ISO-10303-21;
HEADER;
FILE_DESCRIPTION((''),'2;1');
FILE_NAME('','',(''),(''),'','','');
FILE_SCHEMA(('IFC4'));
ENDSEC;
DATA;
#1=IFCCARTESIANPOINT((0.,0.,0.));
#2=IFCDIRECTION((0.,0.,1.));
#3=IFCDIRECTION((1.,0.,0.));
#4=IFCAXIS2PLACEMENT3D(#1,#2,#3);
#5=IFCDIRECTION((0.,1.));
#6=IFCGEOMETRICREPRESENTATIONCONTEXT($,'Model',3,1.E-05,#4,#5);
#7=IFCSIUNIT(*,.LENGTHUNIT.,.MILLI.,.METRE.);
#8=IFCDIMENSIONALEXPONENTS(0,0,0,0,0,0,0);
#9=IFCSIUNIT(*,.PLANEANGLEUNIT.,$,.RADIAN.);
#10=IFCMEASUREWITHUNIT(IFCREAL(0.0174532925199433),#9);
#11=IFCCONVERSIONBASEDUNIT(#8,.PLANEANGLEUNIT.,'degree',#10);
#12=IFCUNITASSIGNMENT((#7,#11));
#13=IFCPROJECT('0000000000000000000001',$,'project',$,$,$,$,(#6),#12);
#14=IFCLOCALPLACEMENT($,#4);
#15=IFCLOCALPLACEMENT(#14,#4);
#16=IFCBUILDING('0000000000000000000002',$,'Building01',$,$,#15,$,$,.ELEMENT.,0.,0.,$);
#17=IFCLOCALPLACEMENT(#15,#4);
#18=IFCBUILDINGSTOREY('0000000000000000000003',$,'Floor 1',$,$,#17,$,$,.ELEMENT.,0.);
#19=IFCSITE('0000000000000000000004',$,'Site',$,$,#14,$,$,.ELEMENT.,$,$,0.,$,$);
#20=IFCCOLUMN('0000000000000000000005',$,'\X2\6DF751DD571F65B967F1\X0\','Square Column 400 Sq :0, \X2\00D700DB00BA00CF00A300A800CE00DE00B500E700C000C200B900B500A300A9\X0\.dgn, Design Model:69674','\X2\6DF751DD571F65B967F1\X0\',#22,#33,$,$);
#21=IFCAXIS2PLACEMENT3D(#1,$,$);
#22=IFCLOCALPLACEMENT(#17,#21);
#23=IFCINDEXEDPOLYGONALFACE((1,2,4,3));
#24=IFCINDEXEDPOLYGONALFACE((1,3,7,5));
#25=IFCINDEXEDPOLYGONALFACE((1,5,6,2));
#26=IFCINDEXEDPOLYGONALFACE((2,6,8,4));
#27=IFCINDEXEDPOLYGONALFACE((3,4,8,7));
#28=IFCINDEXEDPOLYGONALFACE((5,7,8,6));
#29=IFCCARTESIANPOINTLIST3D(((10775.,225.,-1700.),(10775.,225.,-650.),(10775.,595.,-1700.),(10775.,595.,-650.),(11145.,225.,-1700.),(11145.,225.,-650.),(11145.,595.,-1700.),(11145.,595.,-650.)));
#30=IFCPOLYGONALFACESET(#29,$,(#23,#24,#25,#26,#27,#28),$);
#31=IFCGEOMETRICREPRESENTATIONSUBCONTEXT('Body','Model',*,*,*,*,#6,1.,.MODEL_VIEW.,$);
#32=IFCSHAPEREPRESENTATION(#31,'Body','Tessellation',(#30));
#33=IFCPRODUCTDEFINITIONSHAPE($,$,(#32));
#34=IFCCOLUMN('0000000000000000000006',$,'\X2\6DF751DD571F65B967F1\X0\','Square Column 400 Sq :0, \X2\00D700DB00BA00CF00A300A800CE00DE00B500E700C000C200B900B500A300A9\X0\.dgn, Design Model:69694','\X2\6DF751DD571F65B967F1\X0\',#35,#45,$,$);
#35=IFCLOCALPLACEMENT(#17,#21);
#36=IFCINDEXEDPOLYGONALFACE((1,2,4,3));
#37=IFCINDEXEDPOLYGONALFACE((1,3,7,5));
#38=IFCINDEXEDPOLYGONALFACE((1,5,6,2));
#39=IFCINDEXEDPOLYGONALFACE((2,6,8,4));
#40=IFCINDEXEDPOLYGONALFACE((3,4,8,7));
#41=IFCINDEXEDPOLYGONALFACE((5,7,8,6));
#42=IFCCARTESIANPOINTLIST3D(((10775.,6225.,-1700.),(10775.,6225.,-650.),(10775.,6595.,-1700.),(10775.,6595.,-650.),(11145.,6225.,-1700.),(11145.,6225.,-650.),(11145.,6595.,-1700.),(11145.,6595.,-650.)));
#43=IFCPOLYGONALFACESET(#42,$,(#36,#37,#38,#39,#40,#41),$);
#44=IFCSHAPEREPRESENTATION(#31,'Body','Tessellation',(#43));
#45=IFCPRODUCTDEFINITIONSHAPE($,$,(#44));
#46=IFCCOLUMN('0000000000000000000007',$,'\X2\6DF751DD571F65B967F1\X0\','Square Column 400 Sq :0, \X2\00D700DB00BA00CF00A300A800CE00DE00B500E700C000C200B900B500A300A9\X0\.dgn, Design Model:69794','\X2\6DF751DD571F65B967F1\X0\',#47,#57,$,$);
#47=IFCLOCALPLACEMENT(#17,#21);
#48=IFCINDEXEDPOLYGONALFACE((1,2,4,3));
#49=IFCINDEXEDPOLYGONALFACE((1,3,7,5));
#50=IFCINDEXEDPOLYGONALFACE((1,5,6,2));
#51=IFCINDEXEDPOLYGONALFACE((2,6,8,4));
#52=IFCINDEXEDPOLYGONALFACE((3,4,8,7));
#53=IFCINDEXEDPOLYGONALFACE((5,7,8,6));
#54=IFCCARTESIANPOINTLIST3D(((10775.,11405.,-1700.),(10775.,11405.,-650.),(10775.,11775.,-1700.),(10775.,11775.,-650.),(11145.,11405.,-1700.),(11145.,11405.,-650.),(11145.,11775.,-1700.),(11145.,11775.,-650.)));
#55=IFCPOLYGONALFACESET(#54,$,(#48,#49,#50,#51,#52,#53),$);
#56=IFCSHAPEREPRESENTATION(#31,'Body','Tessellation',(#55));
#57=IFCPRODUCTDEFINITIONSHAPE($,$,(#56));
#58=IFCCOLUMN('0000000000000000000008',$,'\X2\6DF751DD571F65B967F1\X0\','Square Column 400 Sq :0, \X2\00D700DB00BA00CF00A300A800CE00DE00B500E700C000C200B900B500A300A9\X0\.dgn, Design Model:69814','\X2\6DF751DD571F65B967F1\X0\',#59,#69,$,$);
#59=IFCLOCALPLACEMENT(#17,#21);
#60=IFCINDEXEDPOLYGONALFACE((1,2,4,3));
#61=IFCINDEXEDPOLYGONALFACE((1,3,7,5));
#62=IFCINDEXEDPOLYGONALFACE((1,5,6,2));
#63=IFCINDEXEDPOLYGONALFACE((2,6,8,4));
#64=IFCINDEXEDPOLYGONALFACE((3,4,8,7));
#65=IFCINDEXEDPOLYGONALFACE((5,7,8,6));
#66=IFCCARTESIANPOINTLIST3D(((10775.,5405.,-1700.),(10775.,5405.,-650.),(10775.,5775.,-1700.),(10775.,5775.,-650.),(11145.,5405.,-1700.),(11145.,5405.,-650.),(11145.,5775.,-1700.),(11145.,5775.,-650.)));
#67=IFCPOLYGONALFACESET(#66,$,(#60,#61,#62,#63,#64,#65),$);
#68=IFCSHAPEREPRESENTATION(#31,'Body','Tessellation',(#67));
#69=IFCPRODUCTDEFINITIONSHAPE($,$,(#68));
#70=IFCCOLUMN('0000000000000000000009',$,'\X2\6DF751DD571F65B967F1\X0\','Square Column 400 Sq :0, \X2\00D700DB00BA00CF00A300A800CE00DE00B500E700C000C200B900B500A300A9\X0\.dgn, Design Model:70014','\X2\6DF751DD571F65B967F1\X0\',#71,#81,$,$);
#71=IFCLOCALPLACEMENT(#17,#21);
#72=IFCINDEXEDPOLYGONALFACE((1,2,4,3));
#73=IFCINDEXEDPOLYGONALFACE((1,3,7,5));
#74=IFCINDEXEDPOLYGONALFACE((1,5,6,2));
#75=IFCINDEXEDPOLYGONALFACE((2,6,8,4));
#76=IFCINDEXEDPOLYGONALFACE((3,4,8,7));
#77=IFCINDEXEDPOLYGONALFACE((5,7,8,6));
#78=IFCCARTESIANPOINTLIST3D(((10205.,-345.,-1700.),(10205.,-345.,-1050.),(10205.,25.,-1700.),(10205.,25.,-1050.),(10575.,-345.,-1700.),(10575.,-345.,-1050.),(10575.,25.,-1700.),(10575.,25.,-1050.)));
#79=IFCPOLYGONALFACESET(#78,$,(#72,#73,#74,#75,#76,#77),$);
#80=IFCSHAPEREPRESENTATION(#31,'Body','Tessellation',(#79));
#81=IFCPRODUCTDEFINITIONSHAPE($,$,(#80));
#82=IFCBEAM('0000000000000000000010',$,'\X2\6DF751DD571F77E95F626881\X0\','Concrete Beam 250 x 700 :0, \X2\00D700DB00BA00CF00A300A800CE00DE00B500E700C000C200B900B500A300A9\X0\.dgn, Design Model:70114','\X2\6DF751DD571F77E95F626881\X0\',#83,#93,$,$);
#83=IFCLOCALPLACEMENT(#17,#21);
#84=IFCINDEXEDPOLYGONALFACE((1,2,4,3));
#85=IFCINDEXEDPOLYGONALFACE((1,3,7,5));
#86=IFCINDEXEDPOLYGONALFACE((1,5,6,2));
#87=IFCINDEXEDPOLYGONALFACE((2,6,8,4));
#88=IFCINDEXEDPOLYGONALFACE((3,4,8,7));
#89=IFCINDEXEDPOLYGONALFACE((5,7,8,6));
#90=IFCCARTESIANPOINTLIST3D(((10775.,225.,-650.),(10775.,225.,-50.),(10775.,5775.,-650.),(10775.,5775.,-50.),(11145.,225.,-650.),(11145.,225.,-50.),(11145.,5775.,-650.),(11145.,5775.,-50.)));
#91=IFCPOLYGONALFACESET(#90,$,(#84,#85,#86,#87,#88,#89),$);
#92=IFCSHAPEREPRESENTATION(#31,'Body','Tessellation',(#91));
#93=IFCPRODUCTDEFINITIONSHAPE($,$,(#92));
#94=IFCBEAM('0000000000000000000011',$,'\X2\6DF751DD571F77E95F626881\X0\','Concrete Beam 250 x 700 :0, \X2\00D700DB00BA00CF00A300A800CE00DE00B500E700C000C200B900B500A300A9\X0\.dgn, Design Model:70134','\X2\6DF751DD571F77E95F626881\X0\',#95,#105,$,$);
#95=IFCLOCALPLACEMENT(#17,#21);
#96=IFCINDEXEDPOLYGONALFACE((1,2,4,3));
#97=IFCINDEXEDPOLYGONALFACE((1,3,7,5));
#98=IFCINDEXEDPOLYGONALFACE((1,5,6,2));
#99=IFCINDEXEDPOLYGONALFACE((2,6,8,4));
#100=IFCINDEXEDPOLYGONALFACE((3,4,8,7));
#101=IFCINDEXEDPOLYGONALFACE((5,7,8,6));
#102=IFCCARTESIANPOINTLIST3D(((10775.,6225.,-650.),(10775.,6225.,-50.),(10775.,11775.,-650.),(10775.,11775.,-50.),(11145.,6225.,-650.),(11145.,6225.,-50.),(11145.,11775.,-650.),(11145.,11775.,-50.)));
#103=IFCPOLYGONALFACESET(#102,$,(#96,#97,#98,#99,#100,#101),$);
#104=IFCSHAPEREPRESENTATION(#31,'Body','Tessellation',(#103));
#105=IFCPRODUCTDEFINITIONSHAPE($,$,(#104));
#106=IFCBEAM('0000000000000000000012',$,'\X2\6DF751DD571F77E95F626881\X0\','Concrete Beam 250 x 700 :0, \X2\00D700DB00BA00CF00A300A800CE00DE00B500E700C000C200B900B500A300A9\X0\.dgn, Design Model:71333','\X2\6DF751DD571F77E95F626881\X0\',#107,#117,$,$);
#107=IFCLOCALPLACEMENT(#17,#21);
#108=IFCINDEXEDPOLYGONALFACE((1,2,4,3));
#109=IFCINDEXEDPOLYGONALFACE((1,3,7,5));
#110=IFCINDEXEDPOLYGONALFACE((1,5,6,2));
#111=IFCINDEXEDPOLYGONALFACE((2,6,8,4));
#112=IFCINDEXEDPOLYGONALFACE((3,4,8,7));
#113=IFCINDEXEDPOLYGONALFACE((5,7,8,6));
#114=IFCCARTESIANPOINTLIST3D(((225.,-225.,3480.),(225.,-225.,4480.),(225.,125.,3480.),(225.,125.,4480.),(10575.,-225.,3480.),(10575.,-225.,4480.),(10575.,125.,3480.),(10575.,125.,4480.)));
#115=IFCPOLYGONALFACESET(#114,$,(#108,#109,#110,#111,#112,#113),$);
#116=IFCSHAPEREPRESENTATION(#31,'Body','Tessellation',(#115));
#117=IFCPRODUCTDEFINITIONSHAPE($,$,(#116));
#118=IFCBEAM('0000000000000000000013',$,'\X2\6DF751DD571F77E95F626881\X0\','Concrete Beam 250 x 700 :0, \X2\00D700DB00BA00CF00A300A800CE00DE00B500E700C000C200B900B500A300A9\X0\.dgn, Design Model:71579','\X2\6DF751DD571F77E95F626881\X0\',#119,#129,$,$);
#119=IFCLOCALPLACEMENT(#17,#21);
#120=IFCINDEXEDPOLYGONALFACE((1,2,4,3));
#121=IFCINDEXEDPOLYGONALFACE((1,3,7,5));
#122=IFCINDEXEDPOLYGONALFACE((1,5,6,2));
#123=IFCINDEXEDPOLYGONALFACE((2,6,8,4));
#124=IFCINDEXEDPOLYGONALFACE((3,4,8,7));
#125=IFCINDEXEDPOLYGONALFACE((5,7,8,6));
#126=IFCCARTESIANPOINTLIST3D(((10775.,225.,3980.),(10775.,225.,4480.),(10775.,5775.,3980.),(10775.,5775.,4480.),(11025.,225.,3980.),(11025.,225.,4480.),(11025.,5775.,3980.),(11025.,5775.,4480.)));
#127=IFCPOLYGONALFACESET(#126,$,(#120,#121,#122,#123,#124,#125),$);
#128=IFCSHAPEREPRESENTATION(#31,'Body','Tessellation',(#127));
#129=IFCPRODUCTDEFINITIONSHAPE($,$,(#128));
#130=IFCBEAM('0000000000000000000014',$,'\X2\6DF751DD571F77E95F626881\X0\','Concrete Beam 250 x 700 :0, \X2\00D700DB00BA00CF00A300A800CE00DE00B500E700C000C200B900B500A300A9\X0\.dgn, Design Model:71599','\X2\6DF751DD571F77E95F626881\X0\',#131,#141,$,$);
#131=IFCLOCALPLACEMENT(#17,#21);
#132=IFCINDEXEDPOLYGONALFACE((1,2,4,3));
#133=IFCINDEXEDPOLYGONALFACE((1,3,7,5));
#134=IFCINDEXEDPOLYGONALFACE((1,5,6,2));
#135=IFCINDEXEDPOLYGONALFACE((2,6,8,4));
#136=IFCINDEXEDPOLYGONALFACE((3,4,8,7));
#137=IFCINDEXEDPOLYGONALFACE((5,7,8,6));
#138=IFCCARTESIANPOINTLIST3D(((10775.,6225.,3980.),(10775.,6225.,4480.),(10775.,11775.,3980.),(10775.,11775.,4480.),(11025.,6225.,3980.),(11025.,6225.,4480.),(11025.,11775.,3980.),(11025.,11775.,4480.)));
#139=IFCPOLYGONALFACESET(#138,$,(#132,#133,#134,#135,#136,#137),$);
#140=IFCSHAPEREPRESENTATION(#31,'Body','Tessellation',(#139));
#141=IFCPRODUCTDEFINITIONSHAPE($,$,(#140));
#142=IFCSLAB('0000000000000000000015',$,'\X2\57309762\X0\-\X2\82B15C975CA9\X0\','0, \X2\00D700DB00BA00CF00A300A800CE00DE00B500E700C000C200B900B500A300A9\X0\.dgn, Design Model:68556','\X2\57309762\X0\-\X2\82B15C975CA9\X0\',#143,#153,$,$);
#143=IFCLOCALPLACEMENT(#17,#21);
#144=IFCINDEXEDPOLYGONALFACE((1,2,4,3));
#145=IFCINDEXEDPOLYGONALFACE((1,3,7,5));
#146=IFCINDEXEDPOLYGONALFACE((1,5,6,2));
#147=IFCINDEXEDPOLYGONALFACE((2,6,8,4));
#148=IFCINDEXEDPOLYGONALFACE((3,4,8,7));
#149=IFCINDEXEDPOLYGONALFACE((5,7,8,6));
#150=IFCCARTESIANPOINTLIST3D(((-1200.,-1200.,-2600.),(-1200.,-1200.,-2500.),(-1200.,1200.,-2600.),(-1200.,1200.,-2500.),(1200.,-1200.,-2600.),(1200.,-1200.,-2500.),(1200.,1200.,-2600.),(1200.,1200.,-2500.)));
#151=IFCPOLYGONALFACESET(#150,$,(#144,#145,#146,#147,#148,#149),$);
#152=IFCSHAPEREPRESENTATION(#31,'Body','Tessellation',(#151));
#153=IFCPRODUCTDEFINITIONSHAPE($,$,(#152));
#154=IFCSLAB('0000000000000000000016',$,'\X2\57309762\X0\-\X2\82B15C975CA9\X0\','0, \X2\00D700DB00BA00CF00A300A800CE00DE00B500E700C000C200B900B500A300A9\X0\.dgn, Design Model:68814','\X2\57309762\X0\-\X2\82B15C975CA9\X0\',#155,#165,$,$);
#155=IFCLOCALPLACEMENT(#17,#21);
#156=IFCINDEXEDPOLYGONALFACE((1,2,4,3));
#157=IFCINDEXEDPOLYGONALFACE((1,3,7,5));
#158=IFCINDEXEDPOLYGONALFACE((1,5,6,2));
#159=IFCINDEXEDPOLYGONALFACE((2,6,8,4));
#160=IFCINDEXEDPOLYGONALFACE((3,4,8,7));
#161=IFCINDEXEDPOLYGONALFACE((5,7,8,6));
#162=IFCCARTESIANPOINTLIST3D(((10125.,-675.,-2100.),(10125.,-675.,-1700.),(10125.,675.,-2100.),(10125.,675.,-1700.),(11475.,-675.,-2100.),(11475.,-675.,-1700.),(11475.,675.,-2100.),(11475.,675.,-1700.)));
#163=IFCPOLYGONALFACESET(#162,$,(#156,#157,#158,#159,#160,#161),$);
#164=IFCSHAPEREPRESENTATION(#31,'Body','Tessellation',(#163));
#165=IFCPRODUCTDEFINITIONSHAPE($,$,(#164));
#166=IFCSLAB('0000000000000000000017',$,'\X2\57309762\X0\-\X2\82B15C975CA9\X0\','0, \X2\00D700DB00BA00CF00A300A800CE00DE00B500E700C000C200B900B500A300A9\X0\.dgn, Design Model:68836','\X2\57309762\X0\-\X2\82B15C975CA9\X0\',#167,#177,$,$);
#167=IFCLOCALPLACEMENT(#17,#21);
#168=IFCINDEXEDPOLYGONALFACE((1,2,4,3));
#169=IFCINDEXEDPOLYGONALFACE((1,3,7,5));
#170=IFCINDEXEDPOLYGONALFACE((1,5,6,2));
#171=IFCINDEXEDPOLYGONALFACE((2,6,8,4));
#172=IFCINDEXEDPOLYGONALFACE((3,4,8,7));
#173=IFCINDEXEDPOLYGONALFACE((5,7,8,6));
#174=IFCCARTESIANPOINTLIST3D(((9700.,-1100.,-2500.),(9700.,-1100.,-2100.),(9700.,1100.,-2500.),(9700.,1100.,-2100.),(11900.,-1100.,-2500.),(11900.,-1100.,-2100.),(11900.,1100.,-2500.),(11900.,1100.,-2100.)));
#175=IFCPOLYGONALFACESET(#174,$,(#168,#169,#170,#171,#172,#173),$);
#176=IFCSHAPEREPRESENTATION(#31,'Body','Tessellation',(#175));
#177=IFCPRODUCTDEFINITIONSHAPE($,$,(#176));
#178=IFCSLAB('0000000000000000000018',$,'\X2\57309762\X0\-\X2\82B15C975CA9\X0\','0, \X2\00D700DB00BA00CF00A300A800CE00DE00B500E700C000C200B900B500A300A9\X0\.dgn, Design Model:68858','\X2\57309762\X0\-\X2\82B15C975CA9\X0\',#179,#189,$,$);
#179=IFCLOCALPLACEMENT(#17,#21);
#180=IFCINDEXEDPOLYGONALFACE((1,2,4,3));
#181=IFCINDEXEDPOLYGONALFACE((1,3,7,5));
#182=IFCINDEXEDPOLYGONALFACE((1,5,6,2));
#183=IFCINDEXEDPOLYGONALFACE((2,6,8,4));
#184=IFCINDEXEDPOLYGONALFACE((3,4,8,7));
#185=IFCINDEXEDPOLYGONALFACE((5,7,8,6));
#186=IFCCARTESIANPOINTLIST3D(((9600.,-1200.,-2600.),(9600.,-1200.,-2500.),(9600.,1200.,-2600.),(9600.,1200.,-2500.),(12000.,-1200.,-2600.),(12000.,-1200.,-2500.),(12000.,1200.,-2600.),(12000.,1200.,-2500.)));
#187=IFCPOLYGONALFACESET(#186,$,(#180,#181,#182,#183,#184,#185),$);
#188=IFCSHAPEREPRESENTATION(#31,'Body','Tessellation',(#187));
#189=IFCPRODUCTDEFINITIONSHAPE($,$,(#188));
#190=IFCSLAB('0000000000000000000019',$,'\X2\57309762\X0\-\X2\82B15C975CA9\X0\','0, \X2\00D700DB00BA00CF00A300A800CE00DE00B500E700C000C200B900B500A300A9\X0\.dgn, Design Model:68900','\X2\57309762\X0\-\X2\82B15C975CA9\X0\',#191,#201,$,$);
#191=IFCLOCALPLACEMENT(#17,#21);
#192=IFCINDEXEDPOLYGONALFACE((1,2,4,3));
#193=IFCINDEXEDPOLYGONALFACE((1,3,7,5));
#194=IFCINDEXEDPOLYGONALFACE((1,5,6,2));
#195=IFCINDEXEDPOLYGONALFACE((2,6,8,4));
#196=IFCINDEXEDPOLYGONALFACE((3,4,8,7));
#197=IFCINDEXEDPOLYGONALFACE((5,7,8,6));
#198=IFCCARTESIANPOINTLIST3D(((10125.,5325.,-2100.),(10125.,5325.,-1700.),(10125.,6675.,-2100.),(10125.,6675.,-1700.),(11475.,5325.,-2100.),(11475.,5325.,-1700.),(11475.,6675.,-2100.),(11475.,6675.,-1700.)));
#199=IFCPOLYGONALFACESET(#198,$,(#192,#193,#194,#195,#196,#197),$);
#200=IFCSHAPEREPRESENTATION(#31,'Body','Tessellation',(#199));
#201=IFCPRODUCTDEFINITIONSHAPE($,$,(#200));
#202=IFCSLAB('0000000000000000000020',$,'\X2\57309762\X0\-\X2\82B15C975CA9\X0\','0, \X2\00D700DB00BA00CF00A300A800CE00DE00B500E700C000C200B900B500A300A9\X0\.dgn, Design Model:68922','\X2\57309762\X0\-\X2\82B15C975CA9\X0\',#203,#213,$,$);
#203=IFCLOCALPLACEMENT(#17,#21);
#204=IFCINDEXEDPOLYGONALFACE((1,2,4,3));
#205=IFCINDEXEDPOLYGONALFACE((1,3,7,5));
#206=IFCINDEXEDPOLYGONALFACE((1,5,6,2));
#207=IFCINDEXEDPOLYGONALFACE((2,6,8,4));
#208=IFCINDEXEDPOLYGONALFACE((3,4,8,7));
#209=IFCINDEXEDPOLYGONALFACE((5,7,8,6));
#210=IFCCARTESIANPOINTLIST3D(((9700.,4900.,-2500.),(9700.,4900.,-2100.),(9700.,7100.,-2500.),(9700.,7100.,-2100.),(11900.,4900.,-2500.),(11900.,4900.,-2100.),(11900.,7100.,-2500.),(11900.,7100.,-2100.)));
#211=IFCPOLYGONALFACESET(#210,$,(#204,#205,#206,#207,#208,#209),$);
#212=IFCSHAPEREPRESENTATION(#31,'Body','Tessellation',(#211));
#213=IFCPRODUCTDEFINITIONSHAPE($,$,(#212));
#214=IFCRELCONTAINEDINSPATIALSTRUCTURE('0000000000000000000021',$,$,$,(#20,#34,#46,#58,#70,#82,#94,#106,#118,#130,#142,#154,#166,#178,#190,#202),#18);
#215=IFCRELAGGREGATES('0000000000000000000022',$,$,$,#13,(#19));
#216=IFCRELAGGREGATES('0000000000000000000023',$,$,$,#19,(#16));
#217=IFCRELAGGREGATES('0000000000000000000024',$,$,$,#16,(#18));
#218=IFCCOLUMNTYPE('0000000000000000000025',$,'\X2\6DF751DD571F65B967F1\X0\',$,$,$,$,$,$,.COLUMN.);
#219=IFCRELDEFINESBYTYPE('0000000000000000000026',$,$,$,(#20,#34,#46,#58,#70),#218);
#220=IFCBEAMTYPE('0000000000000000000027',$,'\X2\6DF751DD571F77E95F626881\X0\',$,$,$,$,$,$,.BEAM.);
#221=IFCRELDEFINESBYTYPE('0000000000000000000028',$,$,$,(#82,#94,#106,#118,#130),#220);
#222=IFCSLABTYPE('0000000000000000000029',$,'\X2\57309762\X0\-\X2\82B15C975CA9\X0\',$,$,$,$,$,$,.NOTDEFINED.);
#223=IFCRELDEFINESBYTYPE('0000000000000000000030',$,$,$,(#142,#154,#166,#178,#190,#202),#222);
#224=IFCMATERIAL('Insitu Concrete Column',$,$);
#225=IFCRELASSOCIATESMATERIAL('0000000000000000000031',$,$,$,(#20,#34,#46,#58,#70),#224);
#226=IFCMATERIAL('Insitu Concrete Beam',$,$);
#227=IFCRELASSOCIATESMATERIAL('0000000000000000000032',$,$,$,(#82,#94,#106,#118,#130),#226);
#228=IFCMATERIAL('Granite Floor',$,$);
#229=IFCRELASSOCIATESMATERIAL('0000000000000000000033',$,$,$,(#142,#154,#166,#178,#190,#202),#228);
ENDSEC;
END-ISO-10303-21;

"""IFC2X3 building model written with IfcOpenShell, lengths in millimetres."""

from ifc_helpers import new_model, entity, si_unit, converted_unit, direction, frame, frame_2d, origin_with_axes, place, context, subcontext, project, spatial, rectangle, extrude, material, type_object, element, save


model = new_model("IFC2X3")

# Units and contexts
model_context = context("Model", 3, precision=1e-05, world=origin_with_axes(), true_north=direction((0.0, 1.0)))
body_context = subcontext(model_context, "Body", "Model", "MODEL_VIEW", scale=1.0)
ifc_project = project(units=[si_unit("LENGTHUNIT", "METRE", prefix="MILLI"), converted_unit("PLANEANGLEUNIT", "degree", entity("IfcReal", 0.0174532925199433), si_unit("PLANEANGLEUNIT", "RADIAN"), dimensions=[0, 0, 0, 0, 0, 0, 0])], contexts=[model_context])

# Site, building, storey
site_placement = place(None, origin_with_axes())
site = spatial("IfcSite", under=ifc_project, at=site_placement, Name="Site", CompositionType="ELEMENT", RefElevation=0.0)
building_placement = place(site_placement, origin_with_axes())
building = spatial("IfcBuilding", under=site, at=building_placement, Name="Building01", CompositionType="ELEMENT", ElevationOfRefHeight=0.0, ElevationOfTerrain=0.0)
storey_placement = place(building_placement, origin_with_axes())
storey = spatial("IfcBuildingStorey", under=building, at=storey_placement, Name="Floor 1", CompositionType="ELEMENT", Elevation=0.0)

# Columns
ifc_material_1 = material(Name="Insitu Concrete Column")
column_type = type_object("IfcColumnType", Name="混凝土方柱", PredefinedType="COLUMN")
for number, where, z_axis, x_axis, name, description in (
    (1, (10775.0, 595.0, -1700.0), (0.0, 0.0, 1.0), (0.0, -1.0, 0.0), "混凝土方柱", "Square Column 400 Sq :0, ×ÛºÏ£¨ÎÞµçÀÂ¹µ£©.dgn, Design Model:69674"),
    (2, (10775.0, 6595.0, -1700.0), (0.0, 0.0, 1.0), (0.0, -1.0, 0.0), "混凝土方柱", "Square Column 400 Sq :0, ×ÛºÏ£¨ÎÞµçÀÂ¹µ£©.dgn, Design Model:69694"),
    (3, (10775.0, 11405.0, -1700.0), (0.0, 0.0, 1.0), (1.0, 0.0, 0.0), "混凝土方柱", "Square Column 400 Sq :0, ×ÛºÏ£¨ÎÞµçÀÂ¹µ£©.dgn, Design Model:69794"),
    (4, (10775.0, 5405.0, -1700.0), (0.0, 0.0, 1.0), (1.0, 0.0, 0.0), "混凝土方柱", "Square Column 400 Sq :0, ×ÛºÏ£¨ÎÞµçÀÂ¹µ£©.dgn, Design Model:69814"),
):
    element("IfcColumn", number, at=place(storey_placement, frame(where, z_axis=z_axis, x_axis=x_axis)), inside=storey, type_object=column_type, material=ifc_material_1, Name=name, Description=description, ObjectType="混凝土方柱", context=body_context, shape_type="SweptSolid", body=[
        extrude(rectangle(XDim=370.0, YDim=370.0, at=frame_2d((185.0, 185.0), x_axis=(0.0, 1.0))), origin_with_axes(), (0.0, 0.0, 1.0), 1050.0),
    ])
column_placement = place(storey_placement, frame((10575.0, 25.0, -1700.0), z_axis=(0.0, 0.0, 1.0), x_axis=(-1.0, 0.0, 0.0)))
element("IfcColumn", 5, at=column_placement, inside=storey, type_object=column_type, material=ifc_material_1, Name="混凝土方柱", Description="Square Column 400 Sq :0, ×ÛºÏ£¨ÎÞµçÀÂ¹µ£©.dgn, Design Model:70014", ObjectType="混凝土方柱", context=body_context, shape_type="SweptSolid", body=[
    extrude(rectangle(XDim=370.0, YDim=370.0, at=frame_2d((185.0, 185.0), x_axis=(0.0, 1.0))), origin_with_axes(), (0.0, 0.0, 1.0), 650.0),
])

# Beams
ifc_material_2 = material(Name="Insitu Concrete Beam")
beam_type = type_object("IfcBeamType", Name="混凝土矩形梁", PredefinedType="BEAM")
for number, where, z_axis, x_axis, name, description in (
    (6, (11145.0, 225.0, -650.0), (0.0, 1.0, 0.0), (-1.0, 0.0, 0.0), "混凝土矩形梁", "Concrete Beam 250 x 700 :0, ×ÛºÏ£¨ÎÞµçÀÂ¹µ£©.dgn, Design Model:70114"),
    (7, (11145.0, 6225.0, -650.0), (0.0, 1.0, 0.0), (-1.0, 0.0, 0.0), "混凝土矩形梁", "Concrete Beam 250 x 700 :0, ×ÛºÏ£¨ÎÞµçÀÂ¹µ£©.dgn, Design Model:70134"),
):
    element("IfcBeam", number, at=place(storey_placement, frame(where, z_axis=z_axis, x_axis=x_axis)), inside=storey, type_object=beam_type, material=ifc_material_2, Name=name, Description=description, ObjectType="混凝土矩形梁", context=body_context, shape_type="SweptSolid", body=[
        extrude(rectangle(XDim=600.0, YDim=370.0, at=frame_2d((185.0, 300.0), x_axis=(0.0, 1.0))), origin_with_axes(), (0.0, 0.0, 1.0), 5550.0),
    ])
beam_placement = place(storey_placement, frame((10575.0, 125.0, 3480.0), z_axis=(-1.0, 0.0, 0.0), x_axis=(0.0, -1.0, 0.0)))
element("IfcBeam", 8, at=beam_placement, inside=storey, type_object=beam_type, material=ifc_material_2, Name="混凝土矩形梁", Description="Concrete Beam 250 x 700 :0, ×ÛºÏ£¨ÎÞµçÀÂ¹µ£©.dgn, Design Model:71333", ObjectType="混凝土矩形梁", context=body_context, shape_type="SweptSolid", body=[
    extrude(rectangle(XDim=1000.0, YDim=350.0, at=frame_2d((175.0, 500.0), x_axis=(0.0, 1.0))), origin_with_axes(), (0.0, 0.0, 1.0), 10350.0),
])
for number, where, z_axis, x_axis, name, description in (
    (9, (10775.0, 5775.0, 3980.0), (0.0, -1.0, 0.0), (1.0, 0.0, 0.0), "混凝土矩形梁", "Concrete Beam 250 x 700 :0, ×ÛºÏ£¨ÎÞµçÀÂ¹µ£©.dgn, Design Model:71579"),
    (10, (10775.0, 11775.0, 3980.0), (0.0, -1.0, 0.0), (1.0, 0.0, 0.0), "混凝土矩形梁", "Concrete Beam 250 x 700 :0, ×ÛºÏ£¨ÎÞµçÀÂ¹µ£©.dgn, Design Model:71599"),
):
    element("IfcBeam", number, at=place(storey_placement, frame(where, z_axis=z_axis, x_axis=x_axis)), inside=storey, type_object=beam_type, material=ifc_material_2, Name=name, Description=description, ObjectType="混凝土矩形梁", context=body_context, shape_type="SweptSolid", body=[
        extrude(rectangle(XDim=500.0, YDim=250.0, at=frame_2d((125.0, 250.0), x_axis=(0.0, 1.0))), origin_with_axes(), (0.0, 0.0, 1.0), 5550.0),
    ])

# Slabs
ifc_material_3 = material(Name="Granite Floor")
slab_type = type_object("IfcSlabType", Name="地面-花岗岩", PredefinedType="NOTDEFINED")
for number, where, z_axis, x_axis, name in (
    (11, (1200.0, 1200.0, -2500.0), (0.0, 0.0, -1.0), (0.0, -1.0, 0.0), "地面-花岗岩"),
):
    element("IfcSlab", number, at=place(storey_placement, frame(where, z_axis=z_axis, x_axis=x_axis)), inside=storey, type_object=slab_type, material=ifc_material_3, Name=name, Description="0, ×ÛºÏ£¨ÎÞµçÀÂ¹µ£©.dgn, Design Model:68556", ObjectType="地面-花岗岩", context=body_context, shape_type="SweptSolid", body=[
        extrude(rectangle(XDim=2400.0, YDim=2400.0, at=frame_2d((1200.0, 1200.0), x_axis=(1.0, 0.0))), origin_with_axes(), (0.0, 0.0, 1.0), 100.0),
    ])
slab_1_placement = place(storey_placement, frame((10125.0, -675.0, -2100.0), z_axis=(0.0, 0.0, 1.0), x_axis=(1.0, 0.0, 0.0)))
element("IfcSlab", 12, at=slab_1_placement, inside=storey, type_object=slab_type, material=ifc_material_3, Name="地面-花岗岩", Description="0, ×ÛºÏ£¨ÎÞµçÀÂ¹µ£©.dgn, Design Model:68814", ObjectType="地面-花岗岩", context=body_context, shape_type="SweptSolid", body=[
    extrude(rectangle(XDim=1350.0, YDim=1350.0, at=frame_2d((675.0, 675.0), x_axis=(1.0, 0.0))), origin_with_axes(), (0.0, 0.0, 1.0), 400.0),
])
slab_2_placement = place(storey_placement, frame((9700.0, -1100.0, -2500.0), z_axis=(0.0, 0.0, 1.0), x_axis=(1.0, 0.0, 0.0)))
element("IfcSlab", 13, at=slab_2_placement, inside=storey, type_object=slab_type, material=ifc_material_3, Name="地面-花岗岩", Description="0, ×ÛºÏ£¨ÎÞµçÀÂ¹µ£©.dgn, Design Model:68836", ObjectType="地面-花岗岩", context=body_context, shape_type="SweptSolid", body=[
    extrude(rectangle(XDim=2200.0, YDim=2200.0, at=frame_2d((1100.0, 1100.0), x_axis=(1.0, 0.0))), origin_with_axes(), (0.0, 0.0, 1.0), 400.0),
])
slab_3_placement = place(storey_placement, frame((12000.0, 1200.0, -2500.0), z_axis=(0.0, 0.0, -1.0), x_axis=(0.0, -1.0, 0.0)))
element("IfcSlab", 14, at=slab_3_placement, inside=storey, type_object=slab_type, material=ifc_material_3, Name="地面-花岗岩", Description="0, ×ÛºÏ£¨ÎÞµçÀÂ¹µ£©.dgn, Design Model:68858", ObjectType="地面-花岗岩", context=body_context, shape_type="SweptSolid", body=[
    extrude(rectangle(XDim=2400.0, YDim=2400.0, at=frame_2d((1200.0, 1200.0), x_axis=(1.0, 0.0))), origin_with_axes(), (0.0, 0.0, 1.0), 100.0),
])
slab_4_placement = place(storey_placement, frame((10125.0, 5325.0, -2100.0), z_axis=(0.0, 0.0, 1.0), x_axis=(1.0, 0.0, 0.0)))
element("IfcSlab", 15, at=slab_4_placement, inside=storey, type_object=slab_type, material=ifc_material_3, Name="地面-花岗岩", Description="0, ×ÛºÏ£¨ÎÞµçÀÂ¹µ£©.dgn, Design Model:68900", ObjectType="地面-花岗岩", context=body_context, shape_type="SweptSolid", body=[
    extrude(rectangle(XDim=1350.0, YDim=1350.0, at=frame_2d((675.0, 675.0), x_axis=(1.0, 0.0))), origin_with_axes(), (0.0, 0.0, 1.0), 400.0),
])
slab_5_placement = place(storey_placement, frame((9700.0, 4900.0, -2500.0), z_axis=(0.0, 0.0, 1.0), x_axis=(1.0, 0.0, 0.0)))
element("IfcSlab", 16, at=slab_5_placement, inside=storey, type_object=slab_type, material=ifc_material_3, Name="地面-花岗岩", Description="0, ×ÛºÏ£¨ÎÞµçÀÂ¹µ£©.dgn, Design Model:68922", ObjectType="地面-花岗岩", context=body_context, shape_type="SweptSolid", body=[
    extrude(rectangle(XDim=2200.0, YDim=2200.0, at=frame_2d((1100.0, 1100.0), x_axis=(1.0, 0.0))), origin_with_axes(), (0.0, 0.0, 1.0), 400.0),
])

save(model, "model.ifc")
